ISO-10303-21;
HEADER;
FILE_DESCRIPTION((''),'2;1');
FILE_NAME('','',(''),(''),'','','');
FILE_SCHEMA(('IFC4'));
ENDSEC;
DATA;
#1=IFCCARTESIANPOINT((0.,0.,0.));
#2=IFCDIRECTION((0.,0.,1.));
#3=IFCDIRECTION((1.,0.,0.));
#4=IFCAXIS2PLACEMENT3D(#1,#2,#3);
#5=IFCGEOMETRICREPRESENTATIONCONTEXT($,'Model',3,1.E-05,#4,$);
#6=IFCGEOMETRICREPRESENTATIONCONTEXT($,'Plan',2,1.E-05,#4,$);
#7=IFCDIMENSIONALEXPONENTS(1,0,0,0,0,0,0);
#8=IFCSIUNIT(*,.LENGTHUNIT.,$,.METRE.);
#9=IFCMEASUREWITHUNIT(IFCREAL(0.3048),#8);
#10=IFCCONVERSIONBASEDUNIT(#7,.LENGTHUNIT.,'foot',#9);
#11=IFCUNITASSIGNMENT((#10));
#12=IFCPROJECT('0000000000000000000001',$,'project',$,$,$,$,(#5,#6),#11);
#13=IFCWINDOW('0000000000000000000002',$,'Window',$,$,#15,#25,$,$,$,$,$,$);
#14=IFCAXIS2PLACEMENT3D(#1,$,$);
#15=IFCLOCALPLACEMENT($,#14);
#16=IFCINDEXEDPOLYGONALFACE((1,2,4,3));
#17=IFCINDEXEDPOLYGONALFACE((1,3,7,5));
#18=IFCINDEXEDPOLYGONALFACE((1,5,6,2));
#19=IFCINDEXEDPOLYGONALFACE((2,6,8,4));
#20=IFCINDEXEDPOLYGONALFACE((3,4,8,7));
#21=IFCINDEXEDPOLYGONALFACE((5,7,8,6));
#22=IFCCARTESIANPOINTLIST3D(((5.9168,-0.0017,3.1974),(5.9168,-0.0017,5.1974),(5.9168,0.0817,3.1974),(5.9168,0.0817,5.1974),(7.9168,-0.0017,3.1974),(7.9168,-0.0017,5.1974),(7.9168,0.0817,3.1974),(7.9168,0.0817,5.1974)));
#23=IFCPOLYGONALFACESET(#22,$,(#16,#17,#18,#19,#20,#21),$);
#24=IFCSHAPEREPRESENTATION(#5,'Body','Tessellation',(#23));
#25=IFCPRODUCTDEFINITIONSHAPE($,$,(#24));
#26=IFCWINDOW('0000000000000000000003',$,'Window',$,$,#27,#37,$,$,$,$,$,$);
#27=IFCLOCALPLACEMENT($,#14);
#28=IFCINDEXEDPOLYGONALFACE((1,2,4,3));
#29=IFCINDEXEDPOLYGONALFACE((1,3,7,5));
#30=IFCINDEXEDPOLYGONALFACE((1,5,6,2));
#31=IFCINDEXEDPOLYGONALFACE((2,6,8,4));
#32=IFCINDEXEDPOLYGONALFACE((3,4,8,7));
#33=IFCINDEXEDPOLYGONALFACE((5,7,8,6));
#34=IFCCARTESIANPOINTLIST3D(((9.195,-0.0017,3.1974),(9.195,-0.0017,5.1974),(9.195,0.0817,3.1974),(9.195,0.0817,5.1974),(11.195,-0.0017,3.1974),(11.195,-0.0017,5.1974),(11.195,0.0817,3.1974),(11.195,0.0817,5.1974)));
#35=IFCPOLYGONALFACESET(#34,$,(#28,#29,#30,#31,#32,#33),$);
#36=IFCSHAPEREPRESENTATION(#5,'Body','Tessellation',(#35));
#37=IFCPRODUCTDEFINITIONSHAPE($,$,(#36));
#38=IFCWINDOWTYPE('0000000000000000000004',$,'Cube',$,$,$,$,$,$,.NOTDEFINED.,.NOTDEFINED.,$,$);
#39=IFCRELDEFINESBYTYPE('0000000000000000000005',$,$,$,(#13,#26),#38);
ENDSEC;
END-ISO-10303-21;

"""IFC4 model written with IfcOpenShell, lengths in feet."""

from ifc_helpers import new_model, entity, si_unit, converted_unit, frame, origin_with_axes, place, context, project, polyline, outline, extrude, shape, source, transform, mapped, type_object, type_shapes, element, save


model = new_model("IFC4")

# Units and contexts
model_context = context("Model", 3, precision=1e-05, world=origin_with_axes())
plan_context = context("Plan", 2, precision=1e-05, world=origin_with_axes())
ifc_project = project(units=[converted_unit("LENGTHUNIT", "foot", entity("IfcReal", 0.3048), si_unit("LENGTHUNIT", "METRE"), dimensions=[1, 0, 0, 0, 0, 0, 0])], contexts=[model_context, plan_context])

# Windows
window_type = type_object("IfcWindowType", Name="Cube", PredefinedType="NOTDEFINED")
shared_shape = source(origin_with_axes(), model_context, None, "SweptSolid", [
    extrude(outline(polyline([(-1.0, -0.0417), (1.0, -0.0417), (1.0, 0.0417), (-1.0, 0.0417), (-1.0, -0.0417)])), frame((0.0, 0.0, 2.0), z_axis=(0.0, 0.0, -1.0), x_axis=(-1.0, 0.0, 0.0)), (0.0, 0.0, 1.0), 2.0),
])
type_shapes(window_type, [shared_shape])
for number, where, z_axis, x_axis, name in (
    (1, (6.9168, 0.04, 3.1974), (0.0, 0.0, 1.0), (1.0, 0.0, 0.0), "Window"),
    (2, (10.195, 0.04, 3.1974), (0.0, 0.0, 1.0), (1.0, 0.0, 0.0), "Window"),
):
    element("IfcWindow", number, at=place(None, frame(where, z_axis=z_axis, x_axis=x_axis)), type_object=window_type, Name=name, shapes=[
        shape(model_context, None, "MappedRepresentation", [mapped(shared_shape, transform((0.0, 0.0, 0.0), x_axis=(1.0, 0.0, 0.0), y_axis=(0.0, 1.0, 0.0), z_axis=(0.0, 0.0, 1.0), scale=1.0))]),
    ])

save(model, "model.ifc")
